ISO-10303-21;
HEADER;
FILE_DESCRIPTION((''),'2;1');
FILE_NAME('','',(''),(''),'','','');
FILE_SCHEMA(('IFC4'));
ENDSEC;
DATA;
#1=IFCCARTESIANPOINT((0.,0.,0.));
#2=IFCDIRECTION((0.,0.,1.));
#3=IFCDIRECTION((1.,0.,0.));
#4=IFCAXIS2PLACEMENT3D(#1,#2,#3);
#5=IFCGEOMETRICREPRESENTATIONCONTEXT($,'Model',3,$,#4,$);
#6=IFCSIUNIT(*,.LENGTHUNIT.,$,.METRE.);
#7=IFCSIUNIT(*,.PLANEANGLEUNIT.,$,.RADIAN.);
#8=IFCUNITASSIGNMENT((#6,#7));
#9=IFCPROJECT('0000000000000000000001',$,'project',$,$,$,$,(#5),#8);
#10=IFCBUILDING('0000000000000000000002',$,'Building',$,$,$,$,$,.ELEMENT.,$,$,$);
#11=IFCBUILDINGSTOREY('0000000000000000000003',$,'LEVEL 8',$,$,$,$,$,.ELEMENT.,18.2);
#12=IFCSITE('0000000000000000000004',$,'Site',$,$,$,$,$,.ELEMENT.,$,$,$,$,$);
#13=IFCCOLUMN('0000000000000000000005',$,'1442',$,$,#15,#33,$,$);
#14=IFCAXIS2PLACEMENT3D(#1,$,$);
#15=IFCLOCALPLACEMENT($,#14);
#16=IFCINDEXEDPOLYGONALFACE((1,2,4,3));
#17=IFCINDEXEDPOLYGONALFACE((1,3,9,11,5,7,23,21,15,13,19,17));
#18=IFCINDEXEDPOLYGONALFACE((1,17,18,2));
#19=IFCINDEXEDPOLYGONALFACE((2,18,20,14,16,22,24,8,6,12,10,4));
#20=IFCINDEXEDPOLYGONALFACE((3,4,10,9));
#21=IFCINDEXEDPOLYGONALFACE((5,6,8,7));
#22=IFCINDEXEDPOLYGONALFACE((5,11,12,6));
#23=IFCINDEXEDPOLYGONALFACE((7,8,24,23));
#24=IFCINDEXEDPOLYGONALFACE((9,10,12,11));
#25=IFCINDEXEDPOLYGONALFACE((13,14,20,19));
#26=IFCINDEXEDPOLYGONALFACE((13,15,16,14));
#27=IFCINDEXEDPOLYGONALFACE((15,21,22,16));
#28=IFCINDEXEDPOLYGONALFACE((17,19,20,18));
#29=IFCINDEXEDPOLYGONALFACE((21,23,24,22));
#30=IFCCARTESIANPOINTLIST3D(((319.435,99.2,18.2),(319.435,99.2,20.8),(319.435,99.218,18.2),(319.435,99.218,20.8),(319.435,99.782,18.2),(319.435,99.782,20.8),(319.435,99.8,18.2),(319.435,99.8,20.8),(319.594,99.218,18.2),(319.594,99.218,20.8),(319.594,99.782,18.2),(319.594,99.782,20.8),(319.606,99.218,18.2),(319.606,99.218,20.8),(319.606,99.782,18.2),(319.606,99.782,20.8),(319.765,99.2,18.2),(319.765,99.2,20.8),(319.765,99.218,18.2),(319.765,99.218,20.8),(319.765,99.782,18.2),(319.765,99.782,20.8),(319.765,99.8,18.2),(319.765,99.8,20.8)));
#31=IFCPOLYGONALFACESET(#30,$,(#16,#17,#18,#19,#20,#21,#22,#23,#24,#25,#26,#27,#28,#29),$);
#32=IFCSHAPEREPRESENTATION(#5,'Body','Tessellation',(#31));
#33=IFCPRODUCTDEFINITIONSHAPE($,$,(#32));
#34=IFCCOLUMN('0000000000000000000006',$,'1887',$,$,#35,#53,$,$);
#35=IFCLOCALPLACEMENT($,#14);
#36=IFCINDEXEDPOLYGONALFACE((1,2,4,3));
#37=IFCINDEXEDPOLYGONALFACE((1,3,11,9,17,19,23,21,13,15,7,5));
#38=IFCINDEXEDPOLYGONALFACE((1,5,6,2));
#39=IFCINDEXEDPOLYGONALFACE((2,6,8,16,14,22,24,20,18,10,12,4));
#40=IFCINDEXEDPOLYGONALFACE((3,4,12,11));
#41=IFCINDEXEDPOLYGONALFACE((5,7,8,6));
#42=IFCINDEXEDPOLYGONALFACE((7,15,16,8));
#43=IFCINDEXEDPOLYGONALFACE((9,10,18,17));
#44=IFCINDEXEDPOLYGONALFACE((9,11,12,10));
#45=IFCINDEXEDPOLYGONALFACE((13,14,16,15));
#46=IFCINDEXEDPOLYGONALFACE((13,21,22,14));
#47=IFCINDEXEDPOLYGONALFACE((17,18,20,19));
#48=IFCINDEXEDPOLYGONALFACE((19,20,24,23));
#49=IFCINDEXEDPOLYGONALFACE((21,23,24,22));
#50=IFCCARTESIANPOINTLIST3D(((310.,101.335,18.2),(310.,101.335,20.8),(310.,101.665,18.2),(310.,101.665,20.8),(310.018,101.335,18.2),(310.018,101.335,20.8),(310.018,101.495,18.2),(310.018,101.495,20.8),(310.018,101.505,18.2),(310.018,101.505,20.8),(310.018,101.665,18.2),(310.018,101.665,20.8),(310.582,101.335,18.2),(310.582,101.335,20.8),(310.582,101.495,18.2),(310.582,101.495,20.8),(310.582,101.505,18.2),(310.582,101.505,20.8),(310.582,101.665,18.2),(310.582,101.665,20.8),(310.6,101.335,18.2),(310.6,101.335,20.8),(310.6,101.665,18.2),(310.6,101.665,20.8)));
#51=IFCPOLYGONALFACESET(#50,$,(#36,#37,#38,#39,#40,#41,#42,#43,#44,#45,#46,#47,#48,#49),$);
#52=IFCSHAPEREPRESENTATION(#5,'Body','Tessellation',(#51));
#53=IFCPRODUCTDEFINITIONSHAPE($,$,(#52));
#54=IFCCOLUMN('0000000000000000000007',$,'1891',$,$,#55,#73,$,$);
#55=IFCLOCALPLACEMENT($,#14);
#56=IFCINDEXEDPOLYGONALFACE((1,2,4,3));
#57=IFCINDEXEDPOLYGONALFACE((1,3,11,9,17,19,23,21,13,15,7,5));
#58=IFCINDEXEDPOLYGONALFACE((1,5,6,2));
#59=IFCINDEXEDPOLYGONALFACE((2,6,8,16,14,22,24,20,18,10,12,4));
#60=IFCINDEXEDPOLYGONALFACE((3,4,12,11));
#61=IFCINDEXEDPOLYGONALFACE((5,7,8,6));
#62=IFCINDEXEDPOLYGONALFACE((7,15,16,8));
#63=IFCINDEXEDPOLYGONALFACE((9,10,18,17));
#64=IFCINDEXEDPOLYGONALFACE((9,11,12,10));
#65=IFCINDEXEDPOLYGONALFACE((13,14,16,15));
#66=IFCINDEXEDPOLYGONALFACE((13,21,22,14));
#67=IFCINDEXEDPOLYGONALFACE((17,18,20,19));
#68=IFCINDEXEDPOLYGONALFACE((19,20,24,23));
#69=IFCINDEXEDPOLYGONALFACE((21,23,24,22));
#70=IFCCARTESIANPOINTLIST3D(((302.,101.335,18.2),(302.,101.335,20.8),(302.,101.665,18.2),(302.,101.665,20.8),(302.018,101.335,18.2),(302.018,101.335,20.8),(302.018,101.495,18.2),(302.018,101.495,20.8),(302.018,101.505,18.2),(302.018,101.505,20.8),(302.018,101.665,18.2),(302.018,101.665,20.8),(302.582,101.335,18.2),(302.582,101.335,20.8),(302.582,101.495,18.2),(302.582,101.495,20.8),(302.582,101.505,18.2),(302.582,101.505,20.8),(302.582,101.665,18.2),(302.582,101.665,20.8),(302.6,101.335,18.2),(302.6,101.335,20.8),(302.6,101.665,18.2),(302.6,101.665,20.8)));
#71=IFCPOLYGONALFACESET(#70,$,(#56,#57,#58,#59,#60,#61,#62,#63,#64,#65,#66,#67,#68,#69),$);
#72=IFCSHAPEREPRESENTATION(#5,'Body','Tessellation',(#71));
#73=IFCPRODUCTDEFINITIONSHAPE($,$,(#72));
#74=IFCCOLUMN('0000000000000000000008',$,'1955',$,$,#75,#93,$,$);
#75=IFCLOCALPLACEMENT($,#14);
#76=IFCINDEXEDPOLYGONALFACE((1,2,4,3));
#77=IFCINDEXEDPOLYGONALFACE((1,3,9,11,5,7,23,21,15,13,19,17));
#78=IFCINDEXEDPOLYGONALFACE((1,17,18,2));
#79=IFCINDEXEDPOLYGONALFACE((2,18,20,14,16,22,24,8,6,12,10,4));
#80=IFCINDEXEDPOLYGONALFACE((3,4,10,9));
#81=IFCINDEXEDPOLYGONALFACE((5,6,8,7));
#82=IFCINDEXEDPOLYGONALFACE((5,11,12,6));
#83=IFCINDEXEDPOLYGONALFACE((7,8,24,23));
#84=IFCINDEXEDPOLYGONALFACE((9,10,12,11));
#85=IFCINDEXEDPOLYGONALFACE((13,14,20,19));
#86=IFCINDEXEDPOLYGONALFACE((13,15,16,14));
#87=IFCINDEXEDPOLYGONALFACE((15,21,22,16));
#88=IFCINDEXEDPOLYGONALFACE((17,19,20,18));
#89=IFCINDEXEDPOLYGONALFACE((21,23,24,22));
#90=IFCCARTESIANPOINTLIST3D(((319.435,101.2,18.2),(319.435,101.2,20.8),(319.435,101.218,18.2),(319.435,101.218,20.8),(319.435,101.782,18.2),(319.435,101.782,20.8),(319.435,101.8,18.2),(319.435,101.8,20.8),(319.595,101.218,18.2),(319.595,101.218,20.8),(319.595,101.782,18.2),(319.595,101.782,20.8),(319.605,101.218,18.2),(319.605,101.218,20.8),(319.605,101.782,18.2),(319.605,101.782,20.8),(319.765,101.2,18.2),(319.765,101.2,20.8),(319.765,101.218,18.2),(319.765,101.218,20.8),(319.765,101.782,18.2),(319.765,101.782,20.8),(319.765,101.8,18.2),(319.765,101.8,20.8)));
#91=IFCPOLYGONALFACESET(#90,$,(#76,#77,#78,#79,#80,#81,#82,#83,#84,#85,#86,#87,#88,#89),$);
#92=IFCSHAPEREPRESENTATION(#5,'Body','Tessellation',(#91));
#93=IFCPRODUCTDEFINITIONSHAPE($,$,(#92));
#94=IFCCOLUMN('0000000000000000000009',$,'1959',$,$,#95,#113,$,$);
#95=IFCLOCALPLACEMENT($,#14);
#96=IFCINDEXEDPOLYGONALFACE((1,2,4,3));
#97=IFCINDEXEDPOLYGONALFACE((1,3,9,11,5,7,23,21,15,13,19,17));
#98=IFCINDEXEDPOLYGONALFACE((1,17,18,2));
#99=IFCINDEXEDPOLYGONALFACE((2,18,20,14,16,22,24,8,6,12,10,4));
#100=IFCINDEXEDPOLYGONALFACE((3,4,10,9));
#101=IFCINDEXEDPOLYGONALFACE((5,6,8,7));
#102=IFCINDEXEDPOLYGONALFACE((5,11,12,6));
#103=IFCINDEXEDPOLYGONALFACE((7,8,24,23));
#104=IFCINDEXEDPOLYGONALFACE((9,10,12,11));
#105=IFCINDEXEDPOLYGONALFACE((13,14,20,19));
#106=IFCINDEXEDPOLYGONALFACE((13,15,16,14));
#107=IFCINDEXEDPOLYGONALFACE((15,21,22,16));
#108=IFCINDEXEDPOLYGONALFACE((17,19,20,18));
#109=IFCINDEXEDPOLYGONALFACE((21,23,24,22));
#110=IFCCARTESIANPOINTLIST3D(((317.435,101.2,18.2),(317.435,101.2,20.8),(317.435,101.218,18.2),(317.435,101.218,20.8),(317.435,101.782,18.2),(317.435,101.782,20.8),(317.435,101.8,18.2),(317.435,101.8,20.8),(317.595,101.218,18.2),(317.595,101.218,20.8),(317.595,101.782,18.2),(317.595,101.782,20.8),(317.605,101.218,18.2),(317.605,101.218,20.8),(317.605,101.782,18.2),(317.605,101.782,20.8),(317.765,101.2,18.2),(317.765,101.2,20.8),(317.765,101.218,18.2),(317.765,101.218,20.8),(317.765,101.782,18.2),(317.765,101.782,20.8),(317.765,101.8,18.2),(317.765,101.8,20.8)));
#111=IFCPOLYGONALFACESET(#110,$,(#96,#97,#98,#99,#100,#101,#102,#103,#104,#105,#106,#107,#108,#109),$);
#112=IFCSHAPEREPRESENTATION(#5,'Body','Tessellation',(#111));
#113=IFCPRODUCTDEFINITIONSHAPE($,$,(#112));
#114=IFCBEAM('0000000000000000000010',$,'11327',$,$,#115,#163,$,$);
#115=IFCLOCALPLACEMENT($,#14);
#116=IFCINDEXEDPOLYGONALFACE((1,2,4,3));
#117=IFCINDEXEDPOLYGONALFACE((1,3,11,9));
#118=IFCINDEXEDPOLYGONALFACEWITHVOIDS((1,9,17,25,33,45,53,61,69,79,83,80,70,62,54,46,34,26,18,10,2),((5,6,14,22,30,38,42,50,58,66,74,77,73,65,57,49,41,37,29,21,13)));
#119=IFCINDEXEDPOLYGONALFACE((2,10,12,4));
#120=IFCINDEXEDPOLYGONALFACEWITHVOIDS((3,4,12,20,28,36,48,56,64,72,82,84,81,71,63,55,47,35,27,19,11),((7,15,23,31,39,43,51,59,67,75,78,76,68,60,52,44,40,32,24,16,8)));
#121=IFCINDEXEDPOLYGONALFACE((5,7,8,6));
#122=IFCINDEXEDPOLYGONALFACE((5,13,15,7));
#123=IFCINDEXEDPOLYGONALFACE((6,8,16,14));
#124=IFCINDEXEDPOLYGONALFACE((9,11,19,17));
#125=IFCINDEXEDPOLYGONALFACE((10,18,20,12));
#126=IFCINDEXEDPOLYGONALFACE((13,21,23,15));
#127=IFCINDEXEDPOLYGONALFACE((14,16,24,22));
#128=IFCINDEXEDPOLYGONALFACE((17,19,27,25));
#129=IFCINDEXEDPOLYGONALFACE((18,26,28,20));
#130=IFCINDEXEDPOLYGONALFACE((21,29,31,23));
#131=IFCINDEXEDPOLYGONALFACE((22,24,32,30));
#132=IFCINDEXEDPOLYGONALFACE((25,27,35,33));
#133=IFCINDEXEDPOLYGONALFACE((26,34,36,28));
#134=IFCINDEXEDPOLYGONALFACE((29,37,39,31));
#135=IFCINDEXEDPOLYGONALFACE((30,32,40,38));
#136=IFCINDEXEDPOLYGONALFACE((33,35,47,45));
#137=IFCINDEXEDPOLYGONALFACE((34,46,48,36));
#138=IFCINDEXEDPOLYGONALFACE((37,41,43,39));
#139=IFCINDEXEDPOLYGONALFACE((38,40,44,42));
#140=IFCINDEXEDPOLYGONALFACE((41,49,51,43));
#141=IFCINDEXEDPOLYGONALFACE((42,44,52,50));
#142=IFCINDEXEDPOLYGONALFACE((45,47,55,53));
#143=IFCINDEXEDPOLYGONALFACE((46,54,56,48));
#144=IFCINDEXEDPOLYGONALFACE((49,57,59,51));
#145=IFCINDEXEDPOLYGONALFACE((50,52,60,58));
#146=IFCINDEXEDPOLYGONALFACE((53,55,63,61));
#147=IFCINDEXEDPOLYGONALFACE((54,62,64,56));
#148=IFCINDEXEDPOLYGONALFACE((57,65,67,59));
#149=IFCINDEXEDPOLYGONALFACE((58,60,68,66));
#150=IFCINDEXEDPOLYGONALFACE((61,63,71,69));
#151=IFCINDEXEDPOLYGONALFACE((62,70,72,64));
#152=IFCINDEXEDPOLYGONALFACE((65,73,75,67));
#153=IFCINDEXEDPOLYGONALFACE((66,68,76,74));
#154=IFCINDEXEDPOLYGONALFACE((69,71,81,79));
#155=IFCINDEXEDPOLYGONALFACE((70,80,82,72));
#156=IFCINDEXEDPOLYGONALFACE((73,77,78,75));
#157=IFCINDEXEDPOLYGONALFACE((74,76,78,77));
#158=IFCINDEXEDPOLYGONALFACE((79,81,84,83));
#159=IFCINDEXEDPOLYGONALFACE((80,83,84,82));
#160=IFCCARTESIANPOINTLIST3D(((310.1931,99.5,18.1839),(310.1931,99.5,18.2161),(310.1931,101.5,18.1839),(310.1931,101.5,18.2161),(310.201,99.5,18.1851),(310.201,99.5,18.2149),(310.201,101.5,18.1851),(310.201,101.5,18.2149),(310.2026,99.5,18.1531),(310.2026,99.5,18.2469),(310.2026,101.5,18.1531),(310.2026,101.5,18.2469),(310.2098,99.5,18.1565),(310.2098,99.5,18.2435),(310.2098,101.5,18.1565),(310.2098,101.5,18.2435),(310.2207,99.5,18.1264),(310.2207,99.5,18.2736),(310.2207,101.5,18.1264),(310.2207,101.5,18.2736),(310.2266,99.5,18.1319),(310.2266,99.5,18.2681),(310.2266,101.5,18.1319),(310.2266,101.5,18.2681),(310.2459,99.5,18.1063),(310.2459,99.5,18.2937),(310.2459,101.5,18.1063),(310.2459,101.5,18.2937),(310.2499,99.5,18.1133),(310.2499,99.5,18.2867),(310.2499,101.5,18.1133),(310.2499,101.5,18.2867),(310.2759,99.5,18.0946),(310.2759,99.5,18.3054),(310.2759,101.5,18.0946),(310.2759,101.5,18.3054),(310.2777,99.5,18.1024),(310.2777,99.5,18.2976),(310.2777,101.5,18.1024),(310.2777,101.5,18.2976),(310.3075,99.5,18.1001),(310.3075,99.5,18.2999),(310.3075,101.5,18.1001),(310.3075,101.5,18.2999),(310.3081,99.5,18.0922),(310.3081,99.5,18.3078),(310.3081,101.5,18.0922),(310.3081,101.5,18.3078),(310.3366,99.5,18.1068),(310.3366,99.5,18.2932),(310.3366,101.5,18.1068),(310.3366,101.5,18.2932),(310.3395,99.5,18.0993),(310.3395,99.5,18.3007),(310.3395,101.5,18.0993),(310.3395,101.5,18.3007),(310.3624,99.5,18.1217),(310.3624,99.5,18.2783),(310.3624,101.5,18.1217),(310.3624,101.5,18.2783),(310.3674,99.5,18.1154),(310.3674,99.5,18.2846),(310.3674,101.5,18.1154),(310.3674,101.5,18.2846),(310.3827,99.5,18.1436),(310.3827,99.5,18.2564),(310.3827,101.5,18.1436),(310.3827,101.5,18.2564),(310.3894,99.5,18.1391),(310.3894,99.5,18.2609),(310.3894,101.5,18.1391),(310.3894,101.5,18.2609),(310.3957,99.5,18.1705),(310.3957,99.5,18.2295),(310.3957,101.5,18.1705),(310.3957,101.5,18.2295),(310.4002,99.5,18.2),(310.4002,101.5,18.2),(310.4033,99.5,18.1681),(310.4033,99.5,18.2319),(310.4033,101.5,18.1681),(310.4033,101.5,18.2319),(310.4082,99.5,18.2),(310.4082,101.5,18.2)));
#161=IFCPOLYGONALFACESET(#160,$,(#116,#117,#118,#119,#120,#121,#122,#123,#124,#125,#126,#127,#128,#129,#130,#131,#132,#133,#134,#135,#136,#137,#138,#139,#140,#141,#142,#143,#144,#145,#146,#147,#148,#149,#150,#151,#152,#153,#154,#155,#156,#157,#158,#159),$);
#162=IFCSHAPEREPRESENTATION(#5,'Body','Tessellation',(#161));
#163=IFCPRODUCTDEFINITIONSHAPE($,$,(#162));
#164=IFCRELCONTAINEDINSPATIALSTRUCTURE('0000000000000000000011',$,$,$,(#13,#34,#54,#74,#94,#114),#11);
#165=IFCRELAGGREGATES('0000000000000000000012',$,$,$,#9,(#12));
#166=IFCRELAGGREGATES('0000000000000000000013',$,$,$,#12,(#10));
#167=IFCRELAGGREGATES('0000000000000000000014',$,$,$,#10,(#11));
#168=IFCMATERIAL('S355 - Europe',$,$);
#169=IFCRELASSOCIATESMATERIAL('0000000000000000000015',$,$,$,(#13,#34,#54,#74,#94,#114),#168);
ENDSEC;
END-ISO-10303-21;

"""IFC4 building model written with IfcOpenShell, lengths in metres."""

from ifc_helpers import new_model, si_unit, frame, origin_with_axes, origin_2d_with_axis, place, context, project, spatial, hollow_circle, i_section, extrude, material, material_profile, profile_set, profile_usage, element, save


model = new_model("IFC4")

# Units and contexts
model_context = context("Model", 3, world=origin_with_axes())
ifc_project = project(units=[si_unit("LENGTHUNIT", "METRE"), si_unit("PLANEANGLEUNIT", "RADIAN")], contexts=[model_context])

# Site, building, storey
site = spatial("IfcSite", under=ifc_project, Name="Site", CompositionType="ELEMENT")
building = spatial("IfcBuilding", under=site, Name="Building", CompositionType="ELEMENT")
storey = spatial("IfcBuildingStorey", under=building, Name="LEVEL 8", CompositionType="ELEMENT", Elevation=18.2)

# Columns
ifc_material = material(Name="S355 - Europe")
ifc_material_profile_1 = material_profile(ifc_material, i_section(OverallWidth=0.33, OverallDepth=0.6, WebThickness=0.012, FlangeThickness=0.018, at=origin_2d_with_axis()))
ifc_profile_set_1 = profile_set([ifc_material_profile_1])
ifc_profile_usage_1 = profile_usage(ifc_profile_set_1, cardinal=10)
column_1_placement = place(None, frame((319.6, 99.5, 18.2), z_axis=(0.0, 0.0, 1.0), x_axis=(1.0, 0.0, 0.0)))
element("IfcColumn", 1, at=column_1_placement, inside=storey, material=ifc_profile_usage_1, Name="1442", context=model_context, shape_type="SweptSolid", body=[
    extrude(i_section(OverallWidth=0.33, OverallDepth=0.6, WebThickness=0.012, FlangeThickness=0.018, at=origin_2d_with_axis()), origin_with_axes(), (0.0, 0.0, 1.0), 2.6),
])
ifc_material_profile_2 = material_profile(ifc_material, i_section(OverallWidth=0.33, OverallDepth=0.6, WebThickness=0.01, FlangeThickness=0.018, at=origin_2d_with_axis()))
ifc_profile_set_2 = profile_set([ifc_material_profile_2])
ifc_profile_usage_2 = profile_usage(ifc_profile_set_2, cardinal=10)
column_2_placement = place(None, frame((310.3, 101.5, 18.2), z_axis=(0.0, 0.0, 1.0), x_axis=(0.0, -1.0, 0.0)))
element("IfcColumn", 2, at=column_2_placement, inside=storey, material=ifc_profile_usage_2, Name="1887", context=model_context, shape_type="SweptSolid", body=[
    extrude(i_section(OverallWidth=0.33, OverallDepth=0.6, WebThickness=0.01, FlangeThickness=0.018, at=origin_2d_with_axis()), origin_with_axes(), (0.0, 0.0, 1.0), 2.6),
])
ifc_material_profile_3 = material_profile(ifc_material, i_section(OverallWidth=0.33, OverallDepth=0.6, WebThickness=0.01, FlangeThickness=0.018, at=origin_2d_with_axis()))
ifc_profile_set_3 = profile_set([ifc_material_profile_3])
ifc_profile_usage_3 = profile_usage(ifc_profile_set_3, cardinal=10)
column_3_placement = place(None, frame((302.3, 101.5, 18.2), z_axis=(0.0, 0.0, 1.0), x_axis=(0.0, -1.0, 0.0)))
element("IfcColumn", 3, at=column_3_placement, inside=storey, material=ifc_profile_usage_3, Name="1891", context=model_context, shape_type="SweptSolid", body=[
    extrude(i_section(OverallWidth=0.33, OverallDepth=0.6, WebThickness=0.01, FlangeThickness=0.018, at=origin_2d_with_axis()), origin_with_axes(), (0.0, 0.0, 1.0), 2.6),
])
ifc_material_profile_4 = material_profile(ifc_material, i_section(OverallWidth=0.33, OverallDepth=0.6, WebThickness=0.01, FlangeThickness=0.018, at=origin_2d_with_axis()))
ifc_profile_set_4 = profile_set([ifc_material_profile_4])
ifc_profile_usage_4 = profile_usage(ifc_profile_set_4, cardinal=10)
column_4_placement = place(None, frame((319.6, 101.5, 18.2), z_axis=(0.0, 0.0, 1.0), x_axis=(1.0, 0.0, 0.0)))
element("IfcColumn", 4, at=column_4_placement, inside=storey, material=ifc_profile_usage_4, Name="1955", context=model_context, shape_type="SweptSolid", body=[
    extrude(i_section(OverallWidth=0.33, OverallDepth=0.6, WebThickness=0.01, FlangeThickness=0.018, at=origin_2d_with_axis()), origin_with_axes(), (0.0, 0.0, 1.0), 2.6),
])
ifc_material_profile_5 = material_profile(ifc_material, i_section(OverallWidth=0.33, OverallDepth=0.6, WebThickness=0.01, FlangeThickness=0.018, at=origin_2d_with_axis()))
ifc_profile_set_5 = profile_set([ifc_material_profile_5])
ifc_profile_usage_5 = profile_usage(ifc_profile_set_5, cardinal=10)
column_5_placement = place(None, frame((317.6, 101.5, 18.2), z_axis=(0.0, 0.0, 1.0), x_axis=(1.0, 0.0, 0.0)))
element("IfcColumn", 5, at=column_5_placement, inside=storey, material=ifc_profile_usage_5, Name="1959", context=model_context, shape_type="SweptSolid", body=[
    extrude(i_section(OverallWidth=0.33, OverallDepth=0.6, WebThickness=0.01, FlangeThickness=0.018, at=origin_2d_with_axis()), origin_with_axes(), (0.0, 0.0, 1.0), 2.6),
])

# Beam
ifc_material_profile_6 = material_profile(ifc_material, hollow_circle(Radius=0.1081, WallThickness=0.008, at=origin_2d_with_axis()))
ifc_profile_set_6 = profile_set([ifc_material_profile_6])
ifc_profile_usage_6 = profile_usage(ifc_profile_set_6, cardinal=10)
beam_1_placement = place(None, frame((310.3, 101.5, 18.2), z_axis=(0.0, -1.0, 0.0), x_axis=(1.0, 0.0, 0.0)))
element("IfcBeam", 6, at=beam_1_placement, inside=storey, material=ifc_profile_usage_6, Name="11327", context=model_context, shape_type="SweptSolid", body=[
    extrude(hollow_circle(Radius=0.1081, WallThickness=0.008, at=origin_2d_with_axis()), origin_with_axes(), (0.0, 0.0, 1.0), 2.0),
])

save(model, "model.ifc")
